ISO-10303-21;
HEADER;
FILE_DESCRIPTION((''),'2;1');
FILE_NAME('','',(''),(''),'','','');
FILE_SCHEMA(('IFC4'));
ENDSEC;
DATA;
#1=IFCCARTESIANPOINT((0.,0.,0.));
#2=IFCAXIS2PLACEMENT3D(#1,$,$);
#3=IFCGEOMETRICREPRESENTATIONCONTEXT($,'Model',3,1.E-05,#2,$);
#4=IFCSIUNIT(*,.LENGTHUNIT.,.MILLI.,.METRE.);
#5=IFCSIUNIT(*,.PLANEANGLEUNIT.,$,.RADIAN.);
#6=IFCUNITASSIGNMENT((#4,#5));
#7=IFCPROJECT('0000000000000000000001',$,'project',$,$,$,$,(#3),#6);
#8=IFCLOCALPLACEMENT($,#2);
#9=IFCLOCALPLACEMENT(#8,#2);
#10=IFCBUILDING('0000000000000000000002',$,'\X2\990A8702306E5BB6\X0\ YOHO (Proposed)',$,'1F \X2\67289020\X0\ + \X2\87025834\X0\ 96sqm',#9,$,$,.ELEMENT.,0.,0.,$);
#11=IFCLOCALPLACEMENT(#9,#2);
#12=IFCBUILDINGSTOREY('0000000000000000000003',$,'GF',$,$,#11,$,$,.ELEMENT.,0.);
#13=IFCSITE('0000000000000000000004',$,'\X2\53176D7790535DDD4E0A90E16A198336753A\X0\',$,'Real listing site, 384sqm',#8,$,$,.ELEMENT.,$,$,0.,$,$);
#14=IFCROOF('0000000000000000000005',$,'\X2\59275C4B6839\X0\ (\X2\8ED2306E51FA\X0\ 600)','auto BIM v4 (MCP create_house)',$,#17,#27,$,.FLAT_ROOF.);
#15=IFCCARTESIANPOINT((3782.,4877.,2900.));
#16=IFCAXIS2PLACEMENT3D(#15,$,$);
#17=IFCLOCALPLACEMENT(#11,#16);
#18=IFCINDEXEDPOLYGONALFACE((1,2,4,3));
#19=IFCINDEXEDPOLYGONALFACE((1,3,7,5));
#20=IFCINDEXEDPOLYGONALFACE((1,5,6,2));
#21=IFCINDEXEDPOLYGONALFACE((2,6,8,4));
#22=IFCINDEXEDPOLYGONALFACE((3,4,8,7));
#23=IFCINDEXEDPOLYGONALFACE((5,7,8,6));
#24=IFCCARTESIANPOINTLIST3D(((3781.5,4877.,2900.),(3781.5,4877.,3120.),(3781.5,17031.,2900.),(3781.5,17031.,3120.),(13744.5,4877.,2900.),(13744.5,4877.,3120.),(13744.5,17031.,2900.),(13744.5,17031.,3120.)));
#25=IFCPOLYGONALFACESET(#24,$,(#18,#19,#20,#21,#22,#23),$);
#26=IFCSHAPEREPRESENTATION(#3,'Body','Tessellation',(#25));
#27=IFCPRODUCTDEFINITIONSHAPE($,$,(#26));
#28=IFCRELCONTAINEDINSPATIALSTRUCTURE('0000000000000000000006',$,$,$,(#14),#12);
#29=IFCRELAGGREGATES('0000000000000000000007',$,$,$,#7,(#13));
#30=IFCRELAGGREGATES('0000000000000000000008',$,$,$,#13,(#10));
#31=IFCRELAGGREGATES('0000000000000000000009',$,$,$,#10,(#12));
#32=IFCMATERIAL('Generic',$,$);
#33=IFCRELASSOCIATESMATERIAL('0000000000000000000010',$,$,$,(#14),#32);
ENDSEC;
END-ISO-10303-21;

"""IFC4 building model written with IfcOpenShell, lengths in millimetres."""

from ifc_helpers import new_model, si_unit, frame, frame_2d, origin, place, context, project, spatial, rectangle, extrude, material, element, save


model = new_model("IFC4")

# Units and contexts
model_context = context("Model", 3, precision=1e-05, world=origin())
ifc_project = project(units=[si_unit("LENGTHUNIT", "METRE", prefix="MILLI"), si_unit("PLANEANGLEUNIT", "RADIAN")], contexts=[model_context])

# Site, building, storey
site_placement = place(None, origin())
site = spatial("IfcSite", under=ifc_project, at=site_placement, Name="北海道川上郡標茶町", ObjectType="Real listing site, 384sqm", CompositionType="ELEMENT", RefElevation=0.0)
building_placement = place(site_placement, origin())
building = spatial("IfcBuilding", under=site, at=building_placement, Name="養蜂の家 YOHO (Proposed)", ObjectType="1F 木造 + 蜂場 96sqm", CompositionType="ELEMENT", ElevationOfRefHeight=0.0, ElevationOfTerrain=0.0)
storey_placement = place(building_placement, origin())
storey = spatial("IfcBuildingStorey", under=building, at=storey_placement, Name="GF", CompositionType="ELEMENT", Elevation=0.0)

# Shared definitions
ifc_material = material(Name="Generic")

# Roof
roof_placement = place(storey_placement, frame((3782.0, 4877.0, 2900.0)))
element("IfcRoof", 1, at=roof_placement, inside=storey, material=ifc_material, Name="大屋根 (軒の出 600)", Description="auto BIM v4 (MCP create_house)", PredefinedType="FLAT_ROOF", context=model_context, shape_type="SweptSolid", body=[
    extrude(rectangle(XDim=9963.0, YDim=12154.0, at=frame_2d((4981.0, 6077.0))), frame((3782.0, 4877.0, 2900.0)), (0.0, 0.0, 1.0), 220.0),
])

save(model, "model.ifc")
